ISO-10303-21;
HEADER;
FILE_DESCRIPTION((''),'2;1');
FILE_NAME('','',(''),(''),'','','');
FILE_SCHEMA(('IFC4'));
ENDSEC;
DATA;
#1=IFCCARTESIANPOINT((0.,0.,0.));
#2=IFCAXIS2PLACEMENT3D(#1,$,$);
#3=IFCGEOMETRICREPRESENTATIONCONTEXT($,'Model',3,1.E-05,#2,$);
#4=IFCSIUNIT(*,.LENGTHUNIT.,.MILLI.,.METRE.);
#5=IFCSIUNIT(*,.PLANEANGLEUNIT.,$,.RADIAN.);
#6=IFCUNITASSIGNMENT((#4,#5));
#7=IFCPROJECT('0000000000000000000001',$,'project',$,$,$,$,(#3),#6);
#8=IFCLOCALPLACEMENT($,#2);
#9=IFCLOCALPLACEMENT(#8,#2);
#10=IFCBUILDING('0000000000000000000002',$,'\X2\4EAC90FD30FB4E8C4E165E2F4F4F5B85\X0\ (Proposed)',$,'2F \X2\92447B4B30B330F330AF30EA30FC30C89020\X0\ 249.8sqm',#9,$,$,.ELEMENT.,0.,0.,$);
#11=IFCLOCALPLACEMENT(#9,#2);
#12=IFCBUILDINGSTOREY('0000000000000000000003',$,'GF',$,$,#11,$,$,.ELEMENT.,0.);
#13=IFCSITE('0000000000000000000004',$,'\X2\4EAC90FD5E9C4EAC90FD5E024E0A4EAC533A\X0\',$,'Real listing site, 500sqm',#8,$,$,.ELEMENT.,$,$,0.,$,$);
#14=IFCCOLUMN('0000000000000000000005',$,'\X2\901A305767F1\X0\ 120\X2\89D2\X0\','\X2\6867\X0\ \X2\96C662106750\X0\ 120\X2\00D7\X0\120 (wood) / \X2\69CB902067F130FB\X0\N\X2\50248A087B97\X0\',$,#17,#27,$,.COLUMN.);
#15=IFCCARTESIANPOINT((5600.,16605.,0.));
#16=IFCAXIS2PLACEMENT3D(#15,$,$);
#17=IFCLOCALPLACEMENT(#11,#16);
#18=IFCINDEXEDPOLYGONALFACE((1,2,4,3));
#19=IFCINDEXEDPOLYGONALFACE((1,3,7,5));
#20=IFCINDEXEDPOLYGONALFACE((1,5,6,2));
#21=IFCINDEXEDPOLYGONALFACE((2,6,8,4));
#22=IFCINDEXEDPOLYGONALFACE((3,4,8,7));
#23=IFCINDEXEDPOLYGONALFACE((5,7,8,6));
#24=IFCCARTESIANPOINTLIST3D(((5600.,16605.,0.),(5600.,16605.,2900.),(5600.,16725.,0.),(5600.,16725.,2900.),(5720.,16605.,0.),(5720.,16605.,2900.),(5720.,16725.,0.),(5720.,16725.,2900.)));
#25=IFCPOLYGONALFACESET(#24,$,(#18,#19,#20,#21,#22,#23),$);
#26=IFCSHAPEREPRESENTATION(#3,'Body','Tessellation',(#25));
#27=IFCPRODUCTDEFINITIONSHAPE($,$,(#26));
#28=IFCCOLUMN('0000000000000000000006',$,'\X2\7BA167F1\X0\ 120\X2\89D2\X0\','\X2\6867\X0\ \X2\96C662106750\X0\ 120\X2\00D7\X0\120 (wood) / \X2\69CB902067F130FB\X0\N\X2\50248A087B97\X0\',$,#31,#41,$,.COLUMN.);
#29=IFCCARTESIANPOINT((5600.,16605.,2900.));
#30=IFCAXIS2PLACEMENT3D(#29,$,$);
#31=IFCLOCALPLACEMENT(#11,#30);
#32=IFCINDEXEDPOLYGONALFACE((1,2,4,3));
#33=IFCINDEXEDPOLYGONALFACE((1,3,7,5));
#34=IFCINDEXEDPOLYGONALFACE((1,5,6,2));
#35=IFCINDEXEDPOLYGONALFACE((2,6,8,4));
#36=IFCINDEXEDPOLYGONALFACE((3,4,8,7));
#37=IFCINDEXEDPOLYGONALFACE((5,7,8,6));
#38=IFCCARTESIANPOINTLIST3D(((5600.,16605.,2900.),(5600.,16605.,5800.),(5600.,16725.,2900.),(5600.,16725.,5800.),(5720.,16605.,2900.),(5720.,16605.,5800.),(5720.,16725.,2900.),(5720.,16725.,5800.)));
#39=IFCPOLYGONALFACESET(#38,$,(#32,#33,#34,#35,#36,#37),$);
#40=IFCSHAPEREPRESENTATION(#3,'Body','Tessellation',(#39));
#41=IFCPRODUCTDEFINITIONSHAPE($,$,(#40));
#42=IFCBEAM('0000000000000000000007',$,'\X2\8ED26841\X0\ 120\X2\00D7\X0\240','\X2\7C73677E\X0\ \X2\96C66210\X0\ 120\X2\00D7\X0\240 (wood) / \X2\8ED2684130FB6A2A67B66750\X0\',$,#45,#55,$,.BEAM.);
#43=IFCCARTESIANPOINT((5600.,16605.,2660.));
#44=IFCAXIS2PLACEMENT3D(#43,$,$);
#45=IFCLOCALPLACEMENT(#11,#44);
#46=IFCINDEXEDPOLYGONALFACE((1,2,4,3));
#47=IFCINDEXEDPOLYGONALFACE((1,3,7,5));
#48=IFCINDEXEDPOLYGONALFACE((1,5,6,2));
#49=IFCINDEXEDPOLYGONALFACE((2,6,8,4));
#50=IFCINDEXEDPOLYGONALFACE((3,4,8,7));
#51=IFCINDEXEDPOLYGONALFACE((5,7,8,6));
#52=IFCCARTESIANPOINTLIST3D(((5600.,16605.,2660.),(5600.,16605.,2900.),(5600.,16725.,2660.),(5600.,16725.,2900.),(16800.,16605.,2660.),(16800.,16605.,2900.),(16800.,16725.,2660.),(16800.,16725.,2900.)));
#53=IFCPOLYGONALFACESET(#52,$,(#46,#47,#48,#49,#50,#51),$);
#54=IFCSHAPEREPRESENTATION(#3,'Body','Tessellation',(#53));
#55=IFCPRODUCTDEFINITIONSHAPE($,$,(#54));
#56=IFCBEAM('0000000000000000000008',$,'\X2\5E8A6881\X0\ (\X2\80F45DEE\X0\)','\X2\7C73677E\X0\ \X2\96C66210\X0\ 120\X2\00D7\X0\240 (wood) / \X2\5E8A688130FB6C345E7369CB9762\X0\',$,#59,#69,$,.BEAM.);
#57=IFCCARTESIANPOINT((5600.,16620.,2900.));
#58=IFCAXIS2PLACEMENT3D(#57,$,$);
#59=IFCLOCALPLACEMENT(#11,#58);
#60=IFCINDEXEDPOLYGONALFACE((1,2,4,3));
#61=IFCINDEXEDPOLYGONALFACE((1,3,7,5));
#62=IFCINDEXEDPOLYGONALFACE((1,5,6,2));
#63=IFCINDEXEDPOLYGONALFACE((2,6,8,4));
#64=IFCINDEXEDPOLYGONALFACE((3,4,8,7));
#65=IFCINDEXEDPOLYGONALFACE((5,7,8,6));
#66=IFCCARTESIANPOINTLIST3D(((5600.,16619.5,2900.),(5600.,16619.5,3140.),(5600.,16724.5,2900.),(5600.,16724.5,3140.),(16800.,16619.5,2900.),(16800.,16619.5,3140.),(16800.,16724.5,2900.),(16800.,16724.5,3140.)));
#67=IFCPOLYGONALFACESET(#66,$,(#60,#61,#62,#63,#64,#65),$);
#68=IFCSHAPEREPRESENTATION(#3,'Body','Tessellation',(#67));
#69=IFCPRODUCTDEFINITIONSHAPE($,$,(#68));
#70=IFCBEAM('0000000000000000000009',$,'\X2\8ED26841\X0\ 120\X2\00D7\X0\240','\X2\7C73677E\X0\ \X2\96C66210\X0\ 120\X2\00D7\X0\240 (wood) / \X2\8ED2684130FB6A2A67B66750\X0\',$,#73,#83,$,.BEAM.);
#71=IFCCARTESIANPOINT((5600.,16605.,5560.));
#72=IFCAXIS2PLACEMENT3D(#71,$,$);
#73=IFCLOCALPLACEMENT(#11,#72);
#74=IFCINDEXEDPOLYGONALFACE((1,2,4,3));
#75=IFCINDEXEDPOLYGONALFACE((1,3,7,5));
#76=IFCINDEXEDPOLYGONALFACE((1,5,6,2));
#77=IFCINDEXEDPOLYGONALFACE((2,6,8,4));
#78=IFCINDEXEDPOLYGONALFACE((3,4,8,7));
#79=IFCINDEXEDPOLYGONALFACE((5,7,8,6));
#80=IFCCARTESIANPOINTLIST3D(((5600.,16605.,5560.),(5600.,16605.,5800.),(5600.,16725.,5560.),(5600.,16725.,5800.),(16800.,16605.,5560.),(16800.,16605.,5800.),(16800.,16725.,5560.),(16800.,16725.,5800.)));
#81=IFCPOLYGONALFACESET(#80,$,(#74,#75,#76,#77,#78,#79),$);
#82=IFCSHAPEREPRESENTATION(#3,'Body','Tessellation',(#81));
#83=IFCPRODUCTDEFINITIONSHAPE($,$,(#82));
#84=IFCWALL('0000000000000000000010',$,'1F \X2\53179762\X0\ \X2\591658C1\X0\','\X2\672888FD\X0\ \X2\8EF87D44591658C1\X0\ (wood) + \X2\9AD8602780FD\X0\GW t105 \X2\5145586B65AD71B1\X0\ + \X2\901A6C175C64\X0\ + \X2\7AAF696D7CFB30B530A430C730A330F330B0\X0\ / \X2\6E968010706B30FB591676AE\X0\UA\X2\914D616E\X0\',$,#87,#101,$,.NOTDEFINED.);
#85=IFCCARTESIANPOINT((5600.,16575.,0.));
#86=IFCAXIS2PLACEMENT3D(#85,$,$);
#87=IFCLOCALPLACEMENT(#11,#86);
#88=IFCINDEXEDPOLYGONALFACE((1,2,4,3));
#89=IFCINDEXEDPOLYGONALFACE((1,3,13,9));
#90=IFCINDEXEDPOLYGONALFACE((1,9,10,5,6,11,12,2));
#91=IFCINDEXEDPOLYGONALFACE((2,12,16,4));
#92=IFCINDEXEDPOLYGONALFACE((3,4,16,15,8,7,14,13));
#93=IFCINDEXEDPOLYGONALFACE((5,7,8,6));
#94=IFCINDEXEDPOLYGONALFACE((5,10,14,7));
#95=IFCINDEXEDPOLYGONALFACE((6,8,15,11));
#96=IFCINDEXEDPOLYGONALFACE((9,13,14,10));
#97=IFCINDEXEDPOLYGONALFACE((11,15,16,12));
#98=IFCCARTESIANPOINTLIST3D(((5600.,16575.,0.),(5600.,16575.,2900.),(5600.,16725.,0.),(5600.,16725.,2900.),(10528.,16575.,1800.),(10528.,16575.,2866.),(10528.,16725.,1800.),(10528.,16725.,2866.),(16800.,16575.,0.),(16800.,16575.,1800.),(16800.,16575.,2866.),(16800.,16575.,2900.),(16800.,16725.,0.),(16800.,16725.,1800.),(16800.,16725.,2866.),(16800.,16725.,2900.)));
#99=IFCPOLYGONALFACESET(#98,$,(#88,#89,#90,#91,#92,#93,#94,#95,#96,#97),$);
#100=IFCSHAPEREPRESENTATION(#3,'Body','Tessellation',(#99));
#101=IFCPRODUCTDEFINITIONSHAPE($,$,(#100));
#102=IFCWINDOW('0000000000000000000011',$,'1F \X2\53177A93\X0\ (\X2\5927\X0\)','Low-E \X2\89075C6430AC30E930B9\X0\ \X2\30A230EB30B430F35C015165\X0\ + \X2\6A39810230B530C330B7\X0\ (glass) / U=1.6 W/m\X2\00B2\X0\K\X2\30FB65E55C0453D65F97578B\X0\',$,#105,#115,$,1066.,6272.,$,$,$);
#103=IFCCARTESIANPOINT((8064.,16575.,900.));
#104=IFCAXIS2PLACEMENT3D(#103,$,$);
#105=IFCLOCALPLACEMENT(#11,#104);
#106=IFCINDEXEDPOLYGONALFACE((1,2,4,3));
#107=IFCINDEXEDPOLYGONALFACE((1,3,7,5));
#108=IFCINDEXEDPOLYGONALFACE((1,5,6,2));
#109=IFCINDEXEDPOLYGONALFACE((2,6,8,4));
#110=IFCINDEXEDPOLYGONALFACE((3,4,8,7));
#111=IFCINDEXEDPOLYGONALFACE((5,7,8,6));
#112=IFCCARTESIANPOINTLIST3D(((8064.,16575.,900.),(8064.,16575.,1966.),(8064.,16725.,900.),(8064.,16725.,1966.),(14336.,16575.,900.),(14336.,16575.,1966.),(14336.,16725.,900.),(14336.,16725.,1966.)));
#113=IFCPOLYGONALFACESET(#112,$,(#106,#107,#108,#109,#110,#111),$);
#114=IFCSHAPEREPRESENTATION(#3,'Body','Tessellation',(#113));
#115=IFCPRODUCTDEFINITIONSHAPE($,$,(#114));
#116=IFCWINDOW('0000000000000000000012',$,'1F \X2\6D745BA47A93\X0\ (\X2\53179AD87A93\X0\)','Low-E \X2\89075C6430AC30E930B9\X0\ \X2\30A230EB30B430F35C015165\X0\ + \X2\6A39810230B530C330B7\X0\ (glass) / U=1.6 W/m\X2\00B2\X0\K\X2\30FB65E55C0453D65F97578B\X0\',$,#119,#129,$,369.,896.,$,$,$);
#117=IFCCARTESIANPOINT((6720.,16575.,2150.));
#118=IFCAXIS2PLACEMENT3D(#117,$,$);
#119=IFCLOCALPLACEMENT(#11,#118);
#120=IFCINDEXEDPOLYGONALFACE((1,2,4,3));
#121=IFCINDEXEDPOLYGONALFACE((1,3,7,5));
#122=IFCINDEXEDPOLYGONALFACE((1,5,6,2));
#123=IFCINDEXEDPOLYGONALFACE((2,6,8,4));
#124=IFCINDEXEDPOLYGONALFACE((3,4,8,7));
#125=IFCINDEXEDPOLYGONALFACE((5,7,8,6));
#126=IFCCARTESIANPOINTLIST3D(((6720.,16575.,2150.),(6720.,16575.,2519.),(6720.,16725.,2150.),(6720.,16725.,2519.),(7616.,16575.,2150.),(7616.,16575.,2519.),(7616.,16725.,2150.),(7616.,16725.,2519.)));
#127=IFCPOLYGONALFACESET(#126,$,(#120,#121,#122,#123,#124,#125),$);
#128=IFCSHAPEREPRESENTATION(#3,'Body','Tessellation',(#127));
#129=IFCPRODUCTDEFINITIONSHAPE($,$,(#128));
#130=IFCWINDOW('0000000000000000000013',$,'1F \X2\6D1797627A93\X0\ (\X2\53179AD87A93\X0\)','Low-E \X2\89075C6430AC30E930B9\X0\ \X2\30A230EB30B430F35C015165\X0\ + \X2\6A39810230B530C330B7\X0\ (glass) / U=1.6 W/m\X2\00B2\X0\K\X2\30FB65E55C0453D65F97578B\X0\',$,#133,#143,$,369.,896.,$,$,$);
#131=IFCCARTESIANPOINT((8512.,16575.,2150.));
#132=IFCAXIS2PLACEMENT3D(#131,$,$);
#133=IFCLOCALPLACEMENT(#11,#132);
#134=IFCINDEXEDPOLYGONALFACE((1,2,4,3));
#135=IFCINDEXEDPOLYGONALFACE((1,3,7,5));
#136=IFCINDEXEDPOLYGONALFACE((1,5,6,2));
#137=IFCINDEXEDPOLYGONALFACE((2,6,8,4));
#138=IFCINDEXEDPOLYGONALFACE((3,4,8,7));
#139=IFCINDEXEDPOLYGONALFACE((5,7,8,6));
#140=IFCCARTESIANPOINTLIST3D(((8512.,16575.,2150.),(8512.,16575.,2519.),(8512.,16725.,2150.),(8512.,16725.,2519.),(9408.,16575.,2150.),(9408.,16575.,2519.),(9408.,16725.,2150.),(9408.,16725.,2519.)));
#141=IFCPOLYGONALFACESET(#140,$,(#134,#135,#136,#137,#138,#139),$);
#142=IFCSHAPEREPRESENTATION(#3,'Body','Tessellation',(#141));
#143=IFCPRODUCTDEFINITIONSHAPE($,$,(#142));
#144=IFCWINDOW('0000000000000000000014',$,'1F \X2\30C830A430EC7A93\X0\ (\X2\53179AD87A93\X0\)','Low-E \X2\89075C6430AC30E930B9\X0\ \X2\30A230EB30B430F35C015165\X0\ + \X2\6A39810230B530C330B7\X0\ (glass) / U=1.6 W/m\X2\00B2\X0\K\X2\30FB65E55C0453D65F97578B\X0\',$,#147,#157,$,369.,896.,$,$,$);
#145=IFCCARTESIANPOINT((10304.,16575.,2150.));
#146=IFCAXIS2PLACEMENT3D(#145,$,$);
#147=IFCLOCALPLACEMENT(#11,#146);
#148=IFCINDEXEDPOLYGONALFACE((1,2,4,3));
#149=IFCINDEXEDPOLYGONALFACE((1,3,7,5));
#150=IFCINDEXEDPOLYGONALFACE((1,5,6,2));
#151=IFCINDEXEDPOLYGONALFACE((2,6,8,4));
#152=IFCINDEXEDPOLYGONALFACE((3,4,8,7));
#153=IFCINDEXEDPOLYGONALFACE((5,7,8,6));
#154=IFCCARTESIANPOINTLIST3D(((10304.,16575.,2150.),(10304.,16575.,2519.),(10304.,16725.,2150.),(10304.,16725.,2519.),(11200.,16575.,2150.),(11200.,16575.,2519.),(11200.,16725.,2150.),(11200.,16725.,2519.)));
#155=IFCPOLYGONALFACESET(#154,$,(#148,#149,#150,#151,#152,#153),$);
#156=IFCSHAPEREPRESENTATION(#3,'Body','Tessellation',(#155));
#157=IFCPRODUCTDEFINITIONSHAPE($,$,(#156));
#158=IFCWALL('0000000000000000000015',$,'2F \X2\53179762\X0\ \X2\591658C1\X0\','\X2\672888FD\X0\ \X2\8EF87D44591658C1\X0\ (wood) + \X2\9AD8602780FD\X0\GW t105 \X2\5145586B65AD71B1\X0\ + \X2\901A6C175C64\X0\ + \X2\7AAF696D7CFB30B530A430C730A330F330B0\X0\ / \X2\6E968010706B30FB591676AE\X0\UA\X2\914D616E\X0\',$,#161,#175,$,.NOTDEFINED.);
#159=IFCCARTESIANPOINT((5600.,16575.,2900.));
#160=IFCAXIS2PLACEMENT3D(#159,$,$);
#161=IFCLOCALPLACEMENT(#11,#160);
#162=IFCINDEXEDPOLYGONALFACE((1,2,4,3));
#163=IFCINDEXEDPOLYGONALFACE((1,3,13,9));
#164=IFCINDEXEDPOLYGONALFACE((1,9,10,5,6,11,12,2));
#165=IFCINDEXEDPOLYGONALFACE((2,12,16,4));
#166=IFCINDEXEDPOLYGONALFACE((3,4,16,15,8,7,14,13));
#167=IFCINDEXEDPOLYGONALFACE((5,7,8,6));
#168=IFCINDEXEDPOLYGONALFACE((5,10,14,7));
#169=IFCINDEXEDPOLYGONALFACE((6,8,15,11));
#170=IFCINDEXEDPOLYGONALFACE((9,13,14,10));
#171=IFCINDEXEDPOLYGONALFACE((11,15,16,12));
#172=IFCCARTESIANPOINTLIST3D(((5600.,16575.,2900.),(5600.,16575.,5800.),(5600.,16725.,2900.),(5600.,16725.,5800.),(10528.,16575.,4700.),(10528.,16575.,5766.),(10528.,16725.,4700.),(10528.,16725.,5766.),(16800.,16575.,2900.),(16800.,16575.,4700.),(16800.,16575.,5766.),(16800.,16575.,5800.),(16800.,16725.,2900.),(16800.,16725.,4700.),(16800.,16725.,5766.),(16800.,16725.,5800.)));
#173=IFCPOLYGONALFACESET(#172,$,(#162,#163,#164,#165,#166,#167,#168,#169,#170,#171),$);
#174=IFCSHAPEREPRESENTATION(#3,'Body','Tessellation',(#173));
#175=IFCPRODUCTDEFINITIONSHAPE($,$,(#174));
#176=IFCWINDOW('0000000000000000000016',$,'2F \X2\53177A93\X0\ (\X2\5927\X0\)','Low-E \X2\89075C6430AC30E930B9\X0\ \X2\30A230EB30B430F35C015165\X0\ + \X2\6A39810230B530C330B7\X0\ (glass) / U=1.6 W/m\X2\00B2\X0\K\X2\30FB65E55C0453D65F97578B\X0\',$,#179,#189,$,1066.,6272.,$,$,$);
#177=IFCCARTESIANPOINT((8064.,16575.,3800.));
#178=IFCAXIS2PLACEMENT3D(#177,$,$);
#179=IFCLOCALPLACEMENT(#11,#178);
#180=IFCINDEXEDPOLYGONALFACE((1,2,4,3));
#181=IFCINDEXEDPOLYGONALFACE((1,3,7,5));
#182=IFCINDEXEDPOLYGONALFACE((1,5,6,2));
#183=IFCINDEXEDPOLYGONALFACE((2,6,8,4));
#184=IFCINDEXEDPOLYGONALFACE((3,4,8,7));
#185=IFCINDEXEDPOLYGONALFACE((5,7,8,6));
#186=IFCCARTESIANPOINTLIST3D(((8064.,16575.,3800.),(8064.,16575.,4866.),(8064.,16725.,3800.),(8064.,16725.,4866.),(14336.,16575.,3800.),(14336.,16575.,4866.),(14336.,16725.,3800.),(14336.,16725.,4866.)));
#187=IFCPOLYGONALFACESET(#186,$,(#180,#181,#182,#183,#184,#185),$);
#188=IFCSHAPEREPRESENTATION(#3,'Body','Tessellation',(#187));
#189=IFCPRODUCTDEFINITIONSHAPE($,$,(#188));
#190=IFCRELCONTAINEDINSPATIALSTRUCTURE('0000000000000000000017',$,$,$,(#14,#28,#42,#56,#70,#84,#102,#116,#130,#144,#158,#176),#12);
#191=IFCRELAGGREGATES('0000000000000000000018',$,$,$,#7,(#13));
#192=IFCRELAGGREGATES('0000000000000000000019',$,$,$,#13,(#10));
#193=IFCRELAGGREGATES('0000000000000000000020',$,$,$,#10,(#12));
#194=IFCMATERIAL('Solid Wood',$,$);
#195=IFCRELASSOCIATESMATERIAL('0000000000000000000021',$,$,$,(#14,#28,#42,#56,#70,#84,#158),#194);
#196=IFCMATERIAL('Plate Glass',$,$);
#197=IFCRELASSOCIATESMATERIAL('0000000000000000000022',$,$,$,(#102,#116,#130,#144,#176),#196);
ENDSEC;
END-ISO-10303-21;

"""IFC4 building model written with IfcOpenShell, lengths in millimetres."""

from ifc_helpers import new_model, si_unit, frame, frame_2d, origin, place, context, project, spatial, rectangle, extrude, material, element, fill, save


model = new_model("IFC4")

# Units and contexts
model_context = context("Model", 3, precision=1e-05, world=origin())
ifc_project = project(units=[si_unit("LENGTHUNIT", "METRE", prefix="MILLI"), si_unit("PLANEANGLEUNIT", "RADIAN")], contexts=[model_context])

# Site, building, storey
site_placement = place(None, origin())
site = spatial("IfcSite", under=ifc_project, at=site_placement, Name="京都府京都市上京区", ObjectType="Real listing site, 500sqm", CompositionType="ELEMENT", RefElevation=0.0)
building_placement = place(site_placement, origin())
building = spatial("IfcBuilding", under=site, at=building_placement, Name="京都・二世帯住宅 (Proposed)", ObjectType="2F 鉄筋コンクリート造 249.8sqm", CompositionType="ELEMENT", ElevationOfRefHeight=0.0, ElevationOfTerrain=0.0)
storey_placement = place(building_placement, origin())
storey = spatial("IfcBuildingStorey", under=building, at=storey_placement, Name="GF", CompositionType="ELEMENT", Elevation=0.0)

# Columns
ifc_material_1 = material(Name="Solid Wood")
column_1_placement = place(storey_placement, frame((5600.0, 16605.0, 0.0)))
element("IfcColumn", 1, at=column_1_placement, inside=storey, material=ifc_material_1, Name="通し柱 120角", Description="桧 集成材 120×120 (wood) / 構造柱・N値計算", PredefinedType="COLUMN", context=model_context, shape_type="SweptSolid", body=[
    extrude(rectangle(XDim=120.0, YDim=120.0, at=frame_2d((60.0, 60.0))), frame((5600.0, 16605.0, 0.0)), (0.0, 0.0, 1.0), 2900.0),
])
column_2_placement = place(storey_placement, frame((5600.0, 16605.0, 2900.0)))
element("IfcColumn", 2, at=column_2_placement, inside=storey, material=ifc_material_1, Name="管柱 120角", Description="桧 集成材 120×120 (wood) / 構造柱・N値計算", PredefinedType="COLUMN", context=model_context, shape_type="SweptSolid", body=[
    extrude(rectangle(XDim=120.0, YDim=120.0, at=frame_2d((60.0, 60.0))), frame((5600.0, 16605.0, 2900.0)), (0.0, 0.0, 1.0), 2900.0),
])

# Beams
beam_1_placement = place(storey_placement, frame((5600.0, 16605.0, 2660.0)))
element("IfcBeam", 3, at=beam_1_placement, inside=storey, material=ifc_material_1, Name="軒桁 120×240", Description="米松 集成 120×240 (wood) / 軒桁・横架材", PredefinedType="BEAM", context=model_context, shape_type="SweptSolid", body=[
    extrude(rectangle(XDim=11200.0, YDim=120.0, at=frame_2d((5600.0, 60.0))), frame((5600.0, 16605.0, 2660.0)), (0.0, 0.0, 1.0), 240.0),
])
beam_2_placement = place(storey_placement, frame((5600.0, 16620.0, 2900.0)))
element("IfcBeam", 4, at=beam_2_placement, inside=storey, material=ifc_material_1, Name="床梁 (胴差)", Description="米松 集成 120×240 (wood) / 床梁・水平構面", PredefinedType="BEAM", context=model_context, shape_type="SweptSolid", body=[
    extrude(rectangle(XDim=11200.0, YDim=105.0, at=frame_2d((5600.0, 52.0))), frame((5600.0, 16620.0, 2900.0)), (0.0, 0.0, 1.0), 240.0),
])
beam_3_placement = place(storey_placement, frame((5600.0, 16605.0, 5560.0)))
element("IfcBeam", 5, at=beam_3_placement, inside=storey, material=ifc_material_1, Name="軒桁 120×240", Description="米松 集成 120×240 (wood) / 軒桁・横架材", PredefinedType="BEAM", context=model_context, shape_type="SweptSolid", body=[
    extrude(rectangle(XDim=11200.0, YDim=120.0, at=frame_2d((5600.0, 60.0))), frame((5600.0, 16605.0, 5560.0)), (0.0, 0.0, 1.0), 240.0),
])

# Wall, openings, windows
wall_1_placement = place(storey_placement, frame((5600.0, 16575.0, 0.0)))
wall_1 = element("IfcWall", 6, at=wall_1_placement, inside=storey, material=ifc_material_1, Name="1F 北面 外壁", Description="木製 軸組外壁 (wood) + 高性能GW t105 充填断熱 + 通気層 + 窯業系サイディング / 準耐火・外皮UA配慮", PredefinedType="NOTDEFINED", context=model_context, shape_type="SweptSolid", body=[
    extrude(rectangle(XDim=11200.0, YDim=150.0, at=frame_2d((5600.0, 75.0))), frame((5600.0, 16575.0, 0.0)), (0.0, 0.0, 1.0), 2900.0),
])
opening_1_placement = place(storey_placement, frame((8064.0, 16575.0, 900.0)))
opening_1 = element("IfcOpeningElement", 7, at=opening_1_placement, cuts=wall_1, PredefinedType="NOTDEFINED", context=model_context, shape_type="SweptSolid", body=[
    extrude(rectangle(XDim=6272.0, YDim=150.0, at=frame_2d((3136.0, 75.0))), frame((8064.0, 16575.0, 900.0)), (0.0, 0.0, 1.0), 1066.0),
])
opening_2_placement = place(storey_placement, frame((6720.0, 16575.0, 2150.0)))
opening_2 = element("IfcOpeningElement", 8, at=opening_2_placement, cuts=wall_1, PredefinedType="NOTDEFINED", context=model_context, shape_type="SweptSolid", body=[
    extrude(rectangle(XDim=896.0, YDim=150.0, at=frame_2d((448.0, 75.0))), frame((6720.0, 16575.0, 2150.0)), (0.0, 0.0, 1.0), 369.0),
])
opening_3_placement = place(storey_placement, frame((8512.0, 16575.0, 2150.0)))
opening_3 = element("IfcOpeningElement", 9, at=opening_3_placement, cuts=wall_1, PredefinedType="NOTDEFINED", context=model_context, shape_type="SweptSolid", body=[
    extrude(rectangle(XDim=896.0, YDim=150.0, at=frame_2d((448.0, 75.0))), frame((8512.0, 16575.0, 2150.0)), (0.0, 0.0, 1.0), 369.0),
])
opening_4_placement = place(storey_placement, frame((10304.0, 16575.0, 2150.0)))
opening_4 = element("IfcOpeningElement", 10, at=opening_4_placement, cuts=wall_1, PredefinedType="NOTDEFINED", context=model_context, shape_type="SweptSolid", body=[
    extrude(rectangle(XDim=896.0, YDim=150.0, at=frame_2d((448.0, 75.0))), frame((10304.0, 16575.0, 2150.0)), (0.0, 0.0, 1.0), 369.0),
])
ifc_material_2 = material(Name="Plate Glass")
window_1_placement = place(storey_placement, frame((8064.0, 16575.0, 900.0)))
window_1 = element("IfcWindow", 11, at=window_1_placement, inside=storey, material=ifc_material_2, Name="1F 北窓 (大)", Description="Low-E 複層ガラス アルゴン封入 + 樹脂サッシ (glass) / U=1.6 W/m²K・日射取得型", OverallHeight=1066.0, OverallWidth=6272.0, context=model_context, shape_type="SweptSolid", body=[
    extrude(rectangle(XDim=6272.0, YDim=150.0, at=frame_2d((3136.0, 75.0))), frame((8064.0, 16575.0, 900.0)), (0.0, 0.0, 1.0), 1066.0),
])
fill(opening_1, window_1)
window_2_placement = place(storey_placement, frame((6720.0, 16575.0, 2150.0)))
window_2 = element("IfcWindow", 12, at=window_2_placement, inside=storey, material=ifc_material_2, Name="1F 浴室窓 (北高窓)", Description="Low-E 複層ガラス アルゴン封入 + 樹脂サッシ (glass) / U=1.6 W/m²K・日射取得型", OverallHeight=369.0, OverallWidth=896.0, context=model_context, shape_type="SweptSolid", body=[
    extrude(rectangle(XDim=896.0, YDim=150.0, at=frame_2d((448.0, 75.0))), frame((6720.0, 16575.0, 2150.0)), (0.0, 0.0, 1.0), 369.0),
])
fill(opening_2, window_2)
window_3_placement = place(storey_placement, frame((8512.0, 16575.0, 2150.0)))
window_3 = element("IfcWindow", 13, at=window_3_placement, inside=storey, material=ifc_material_2, Name="1F 洗面窓 (北高窓)", Description="Low-E 複層ガラス アルゴン封入 + 樹脂サッシ (glass) / U=1.6 W/m²K・日射取得型", OverallHeight=369.0, OverallWidth=896.0, context=model_context, shape_type="SweptSolid", body=[
    extrude(rectangle(XDim=896.0, YDim=150.0, at=frame_2d((448.0, 75.0))), frame((8512.0, 16575.0, 2150.0)), (0.0, 0.0, 1.0), 369.0),
])
fill(opening_3, window_3)
window_4_placement = place(storey_placement, frame((10304.0, 16575.0, 2150.0)))
window_4 = element("IfcWindow", 14, at=window_4_placement, inside=storey, material=ifc_material_2, Name="1F トイレ窓 (北高窓)", Description="Low-E 複層ガラス アルゴン封入 + 樹脂サッシ (glass) / U=1.6 W/m²K・日射取得型", OverallHeight=369.0, OverallWidth=896.0, context=model_context, shape_type="SweptSolid", body=[
    extrude(rectangle(XDim=896.0, YDim=150.0, at=frame_2d((448.0, 75.0))), frame((10304.0, 16575.0, 2150.0)), (0.0, 0.0, 1.0), 369.0),
])
fill(opening_4, window_4)

# Wall, opening, window
wall_2_placement = place(storey_placement, frame((5600.0, 16575.0, 2900.0)))
wall_2 = element("IfcWall", 15, at=wall_2_placement, inside=storey, material=ifc_material_1, Name="2F 北面 外壁", Description="木製 軸組外壁 (wood) + 高性能GW t105 充填断熱 + 通気層 + 窯業系サイディング / 準耐火・外皮UA配慮", PredefinedType="NOTDEFINED", context=model_context, shape_type="SweptSolid", body=[
    extrude(rectangle(XDim=11200.0, YDim=150.0, at=frame_2d((5600.0, 75.0))), frame((5600.0, 16575.0, 2900.0)), (0.0, 0.0, 1.0), 2900.0),
])
opening_5_placement = place(storey_placement, frame((8064.0, 16575.0, 3800.0)))
opening_5 = element("IfcOpeningElement", 16, at=opening_5_placement, cuts=wall_2, PredefinedType="NOTDEFINED", context=model_context, shape_type="SweptSolid", body=[
    extrude(rectangle(XDim=6272.0, YDim=150.0, at=frame_2d((3136.0, 75.0))), frame((8064.0, 16575.0, 3800.0)), (0.0, 0.0, 1.0), 1066.0),
])
window_5_placement = place(storey_placement, frame((8064.0, 16575.0, 3800.0)))
window_5 = element("IfcWindow", 17, at=window_5_placement, inside=storey, material=ifc_material_2, Name="2F 北窓 (大)", Description="Low-E 複層ガラス アルゴン封入 + 樹脂サッシ (glass) / U=1.6 W/m²K・日射取得型", OverallHeight=1066.0, OverallWidth=6272.0, context=model_context, shape_type="SweptSolid", body=[
    extrude(rectangle(XDim=6272.0, YDim=150.0, at=frame_2d((3136.0, 75.0))), frame((8064.0, 16575.0, 3800.0)), (0.0, 0.0, 1.0), 1066.0),
])
fill(opening_5, window_5)

save(model, "model.ifc")
